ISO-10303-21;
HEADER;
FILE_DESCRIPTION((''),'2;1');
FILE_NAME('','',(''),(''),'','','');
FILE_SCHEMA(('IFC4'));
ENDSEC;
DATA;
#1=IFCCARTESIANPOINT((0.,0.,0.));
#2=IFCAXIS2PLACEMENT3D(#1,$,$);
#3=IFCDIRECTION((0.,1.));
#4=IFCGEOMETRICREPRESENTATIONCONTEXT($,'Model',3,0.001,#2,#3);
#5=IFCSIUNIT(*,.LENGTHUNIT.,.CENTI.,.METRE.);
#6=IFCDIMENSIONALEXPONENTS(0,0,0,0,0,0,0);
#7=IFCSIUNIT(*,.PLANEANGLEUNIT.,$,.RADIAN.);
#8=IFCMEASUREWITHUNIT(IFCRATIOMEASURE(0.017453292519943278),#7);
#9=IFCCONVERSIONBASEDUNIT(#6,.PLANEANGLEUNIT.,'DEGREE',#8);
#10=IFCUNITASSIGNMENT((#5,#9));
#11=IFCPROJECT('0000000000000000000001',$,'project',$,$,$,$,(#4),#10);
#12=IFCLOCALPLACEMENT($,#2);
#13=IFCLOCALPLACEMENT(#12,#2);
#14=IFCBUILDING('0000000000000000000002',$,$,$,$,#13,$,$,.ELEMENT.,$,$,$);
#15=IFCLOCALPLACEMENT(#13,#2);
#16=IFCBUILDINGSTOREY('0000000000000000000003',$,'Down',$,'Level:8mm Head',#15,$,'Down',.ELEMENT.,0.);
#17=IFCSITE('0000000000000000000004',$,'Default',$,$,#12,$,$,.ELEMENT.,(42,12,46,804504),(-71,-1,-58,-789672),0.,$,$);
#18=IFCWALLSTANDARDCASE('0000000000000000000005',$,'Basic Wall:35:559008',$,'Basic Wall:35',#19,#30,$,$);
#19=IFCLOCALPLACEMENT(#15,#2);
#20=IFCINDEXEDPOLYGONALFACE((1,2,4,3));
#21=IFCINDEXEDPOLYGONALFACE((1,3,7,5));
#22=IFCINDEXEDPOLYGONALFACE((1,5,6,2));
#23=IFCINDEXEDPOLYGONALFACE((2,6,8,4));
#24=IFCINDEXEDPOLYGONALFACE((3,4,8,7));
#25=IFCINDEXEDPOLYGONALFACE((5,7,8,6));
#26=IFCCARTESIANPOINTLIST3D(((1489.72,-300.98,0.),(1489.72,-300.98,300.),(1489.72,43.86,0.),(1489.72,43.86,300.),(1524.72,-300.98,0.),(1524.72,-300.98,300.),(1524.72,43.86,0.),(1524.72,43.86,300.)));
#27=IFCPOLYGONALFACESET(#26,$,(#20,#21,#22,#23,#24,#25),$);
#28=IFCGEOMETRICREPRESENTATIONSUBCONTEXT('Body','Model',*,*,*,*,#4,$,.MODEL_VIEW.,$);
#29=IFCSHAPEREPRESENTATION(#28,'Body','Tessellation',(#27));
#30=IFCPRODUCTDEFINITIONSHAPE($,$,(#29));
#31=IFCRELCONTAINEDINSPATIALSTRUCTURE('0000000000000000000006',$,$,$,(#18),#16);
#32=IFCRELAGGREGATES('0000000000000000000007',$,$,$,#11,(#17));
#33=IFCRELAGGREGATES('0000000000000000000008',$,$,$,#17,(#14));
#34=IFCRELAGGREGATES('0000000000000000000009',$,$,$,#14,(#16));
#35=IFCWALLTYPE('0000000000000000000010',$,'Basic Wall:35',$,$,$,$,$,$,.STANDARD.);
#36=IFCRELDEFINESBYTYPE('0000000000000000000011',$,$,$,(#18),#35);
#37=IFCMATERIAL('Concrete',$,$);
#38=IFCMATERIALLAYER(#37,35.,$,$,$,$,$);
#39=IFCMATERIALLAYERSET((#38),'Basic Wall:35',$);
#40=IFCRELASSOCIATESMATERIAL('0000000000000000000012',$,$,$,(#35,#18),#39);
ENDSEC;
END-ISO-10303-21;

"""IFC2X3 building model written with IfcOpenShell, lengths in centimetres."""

from ifc_helpers import new_model, entity, si_unit, converted_unit, direction, frame, frame_2d, origin, place, context, subcontext, project, spatial, rectangle, extrude, material, layer, layer_set, layer_usage, type_object, element, save


model = new_model("IFC2X3")

# Units and contexts
model_context = context("Model", 3, precision=0.001, world=origin(), true_north=direction((0.0, 1.0)))
body_context = subcontext(model_context, "Body", "Model", "MODEL_VIEW")
ifc_project = project(units=[si_unit("LENGTHUNIT", "METRE", prefix="CENTI"), converted_unit("PLANEANGLEUNIT", "DEGREE", entity("IfcRatioMeasure", 0.017453292519943278), si_unit("PLANEANGLEUNIT", "RADIAN"), dimensions=[0, 0, 0, 0, 0, 0, 0])], contexts=[model_context])

# Site, building, storey
site_placement = place(None, origin())
site = spatial("IfcSite", under=ifc_project, at=site_placement, Name="Default", CompositionType="ELEMENT", RefLatitude=(42, 12, 46, 804504), RefLongitude=(-71, -1, -58, -789672), RefElevation=0.0)
building_placement = place(site_placement, origin())
building = spatial("IfcBuilding", under=site, at=building_placement, CompositionType="ELEMENT")
storey_placement = place(building_placement, origin())
storey = spatial("IfcBuildingStorey", under=building, at=storey_placement, Name="Down", ObjectType="Level:8mm Head", LongName="Down", CompositionType="ELEMENT", Elevation=0.0)

# Wall
ifc_material = material(Name="Concrete")
ifc_layer_1 = layer(ifc_material, 35.0)
ifc_layer_set_1 = layer_set([ifc_layer_1], Name="Basic Wall:35")
ifc_layer_usage_1 = layer_usage(ifc_layer_set_1, "AXIS2", "POSITIVE", -17.5)
wall_type_1 = type_object("IfcWallType", Name="Basic Wall:35", PredefinedType="STANDARD", material=ifc_layer_set_1)
wall_1_placement = place(storey_placement, frame((1507.22, -300.98, 0.0), z_axis=(0.0, 0.0, 1.0), x_axis=(0.0, 1.0, 0.0)))
element("IfcWallStandardCase", 1, at=wall_1_placement, inside=storey, type_object=wall_type_1, material=ifc_layer_usage_1, Name="Basic Wall:35:559008", ObjectType="Basic Wall:35", context=body_context, shape_type="SweptSolid", body=[
    extrude(rectangle(XDim=344.84, YDim=35.0, at=frame_2d((172.42, 0.0), x_axis=(-1.0, 0.0))), origin(), (0.0, 0.0, 1.0), 300.0),
])

save(model, "model.ifc")
